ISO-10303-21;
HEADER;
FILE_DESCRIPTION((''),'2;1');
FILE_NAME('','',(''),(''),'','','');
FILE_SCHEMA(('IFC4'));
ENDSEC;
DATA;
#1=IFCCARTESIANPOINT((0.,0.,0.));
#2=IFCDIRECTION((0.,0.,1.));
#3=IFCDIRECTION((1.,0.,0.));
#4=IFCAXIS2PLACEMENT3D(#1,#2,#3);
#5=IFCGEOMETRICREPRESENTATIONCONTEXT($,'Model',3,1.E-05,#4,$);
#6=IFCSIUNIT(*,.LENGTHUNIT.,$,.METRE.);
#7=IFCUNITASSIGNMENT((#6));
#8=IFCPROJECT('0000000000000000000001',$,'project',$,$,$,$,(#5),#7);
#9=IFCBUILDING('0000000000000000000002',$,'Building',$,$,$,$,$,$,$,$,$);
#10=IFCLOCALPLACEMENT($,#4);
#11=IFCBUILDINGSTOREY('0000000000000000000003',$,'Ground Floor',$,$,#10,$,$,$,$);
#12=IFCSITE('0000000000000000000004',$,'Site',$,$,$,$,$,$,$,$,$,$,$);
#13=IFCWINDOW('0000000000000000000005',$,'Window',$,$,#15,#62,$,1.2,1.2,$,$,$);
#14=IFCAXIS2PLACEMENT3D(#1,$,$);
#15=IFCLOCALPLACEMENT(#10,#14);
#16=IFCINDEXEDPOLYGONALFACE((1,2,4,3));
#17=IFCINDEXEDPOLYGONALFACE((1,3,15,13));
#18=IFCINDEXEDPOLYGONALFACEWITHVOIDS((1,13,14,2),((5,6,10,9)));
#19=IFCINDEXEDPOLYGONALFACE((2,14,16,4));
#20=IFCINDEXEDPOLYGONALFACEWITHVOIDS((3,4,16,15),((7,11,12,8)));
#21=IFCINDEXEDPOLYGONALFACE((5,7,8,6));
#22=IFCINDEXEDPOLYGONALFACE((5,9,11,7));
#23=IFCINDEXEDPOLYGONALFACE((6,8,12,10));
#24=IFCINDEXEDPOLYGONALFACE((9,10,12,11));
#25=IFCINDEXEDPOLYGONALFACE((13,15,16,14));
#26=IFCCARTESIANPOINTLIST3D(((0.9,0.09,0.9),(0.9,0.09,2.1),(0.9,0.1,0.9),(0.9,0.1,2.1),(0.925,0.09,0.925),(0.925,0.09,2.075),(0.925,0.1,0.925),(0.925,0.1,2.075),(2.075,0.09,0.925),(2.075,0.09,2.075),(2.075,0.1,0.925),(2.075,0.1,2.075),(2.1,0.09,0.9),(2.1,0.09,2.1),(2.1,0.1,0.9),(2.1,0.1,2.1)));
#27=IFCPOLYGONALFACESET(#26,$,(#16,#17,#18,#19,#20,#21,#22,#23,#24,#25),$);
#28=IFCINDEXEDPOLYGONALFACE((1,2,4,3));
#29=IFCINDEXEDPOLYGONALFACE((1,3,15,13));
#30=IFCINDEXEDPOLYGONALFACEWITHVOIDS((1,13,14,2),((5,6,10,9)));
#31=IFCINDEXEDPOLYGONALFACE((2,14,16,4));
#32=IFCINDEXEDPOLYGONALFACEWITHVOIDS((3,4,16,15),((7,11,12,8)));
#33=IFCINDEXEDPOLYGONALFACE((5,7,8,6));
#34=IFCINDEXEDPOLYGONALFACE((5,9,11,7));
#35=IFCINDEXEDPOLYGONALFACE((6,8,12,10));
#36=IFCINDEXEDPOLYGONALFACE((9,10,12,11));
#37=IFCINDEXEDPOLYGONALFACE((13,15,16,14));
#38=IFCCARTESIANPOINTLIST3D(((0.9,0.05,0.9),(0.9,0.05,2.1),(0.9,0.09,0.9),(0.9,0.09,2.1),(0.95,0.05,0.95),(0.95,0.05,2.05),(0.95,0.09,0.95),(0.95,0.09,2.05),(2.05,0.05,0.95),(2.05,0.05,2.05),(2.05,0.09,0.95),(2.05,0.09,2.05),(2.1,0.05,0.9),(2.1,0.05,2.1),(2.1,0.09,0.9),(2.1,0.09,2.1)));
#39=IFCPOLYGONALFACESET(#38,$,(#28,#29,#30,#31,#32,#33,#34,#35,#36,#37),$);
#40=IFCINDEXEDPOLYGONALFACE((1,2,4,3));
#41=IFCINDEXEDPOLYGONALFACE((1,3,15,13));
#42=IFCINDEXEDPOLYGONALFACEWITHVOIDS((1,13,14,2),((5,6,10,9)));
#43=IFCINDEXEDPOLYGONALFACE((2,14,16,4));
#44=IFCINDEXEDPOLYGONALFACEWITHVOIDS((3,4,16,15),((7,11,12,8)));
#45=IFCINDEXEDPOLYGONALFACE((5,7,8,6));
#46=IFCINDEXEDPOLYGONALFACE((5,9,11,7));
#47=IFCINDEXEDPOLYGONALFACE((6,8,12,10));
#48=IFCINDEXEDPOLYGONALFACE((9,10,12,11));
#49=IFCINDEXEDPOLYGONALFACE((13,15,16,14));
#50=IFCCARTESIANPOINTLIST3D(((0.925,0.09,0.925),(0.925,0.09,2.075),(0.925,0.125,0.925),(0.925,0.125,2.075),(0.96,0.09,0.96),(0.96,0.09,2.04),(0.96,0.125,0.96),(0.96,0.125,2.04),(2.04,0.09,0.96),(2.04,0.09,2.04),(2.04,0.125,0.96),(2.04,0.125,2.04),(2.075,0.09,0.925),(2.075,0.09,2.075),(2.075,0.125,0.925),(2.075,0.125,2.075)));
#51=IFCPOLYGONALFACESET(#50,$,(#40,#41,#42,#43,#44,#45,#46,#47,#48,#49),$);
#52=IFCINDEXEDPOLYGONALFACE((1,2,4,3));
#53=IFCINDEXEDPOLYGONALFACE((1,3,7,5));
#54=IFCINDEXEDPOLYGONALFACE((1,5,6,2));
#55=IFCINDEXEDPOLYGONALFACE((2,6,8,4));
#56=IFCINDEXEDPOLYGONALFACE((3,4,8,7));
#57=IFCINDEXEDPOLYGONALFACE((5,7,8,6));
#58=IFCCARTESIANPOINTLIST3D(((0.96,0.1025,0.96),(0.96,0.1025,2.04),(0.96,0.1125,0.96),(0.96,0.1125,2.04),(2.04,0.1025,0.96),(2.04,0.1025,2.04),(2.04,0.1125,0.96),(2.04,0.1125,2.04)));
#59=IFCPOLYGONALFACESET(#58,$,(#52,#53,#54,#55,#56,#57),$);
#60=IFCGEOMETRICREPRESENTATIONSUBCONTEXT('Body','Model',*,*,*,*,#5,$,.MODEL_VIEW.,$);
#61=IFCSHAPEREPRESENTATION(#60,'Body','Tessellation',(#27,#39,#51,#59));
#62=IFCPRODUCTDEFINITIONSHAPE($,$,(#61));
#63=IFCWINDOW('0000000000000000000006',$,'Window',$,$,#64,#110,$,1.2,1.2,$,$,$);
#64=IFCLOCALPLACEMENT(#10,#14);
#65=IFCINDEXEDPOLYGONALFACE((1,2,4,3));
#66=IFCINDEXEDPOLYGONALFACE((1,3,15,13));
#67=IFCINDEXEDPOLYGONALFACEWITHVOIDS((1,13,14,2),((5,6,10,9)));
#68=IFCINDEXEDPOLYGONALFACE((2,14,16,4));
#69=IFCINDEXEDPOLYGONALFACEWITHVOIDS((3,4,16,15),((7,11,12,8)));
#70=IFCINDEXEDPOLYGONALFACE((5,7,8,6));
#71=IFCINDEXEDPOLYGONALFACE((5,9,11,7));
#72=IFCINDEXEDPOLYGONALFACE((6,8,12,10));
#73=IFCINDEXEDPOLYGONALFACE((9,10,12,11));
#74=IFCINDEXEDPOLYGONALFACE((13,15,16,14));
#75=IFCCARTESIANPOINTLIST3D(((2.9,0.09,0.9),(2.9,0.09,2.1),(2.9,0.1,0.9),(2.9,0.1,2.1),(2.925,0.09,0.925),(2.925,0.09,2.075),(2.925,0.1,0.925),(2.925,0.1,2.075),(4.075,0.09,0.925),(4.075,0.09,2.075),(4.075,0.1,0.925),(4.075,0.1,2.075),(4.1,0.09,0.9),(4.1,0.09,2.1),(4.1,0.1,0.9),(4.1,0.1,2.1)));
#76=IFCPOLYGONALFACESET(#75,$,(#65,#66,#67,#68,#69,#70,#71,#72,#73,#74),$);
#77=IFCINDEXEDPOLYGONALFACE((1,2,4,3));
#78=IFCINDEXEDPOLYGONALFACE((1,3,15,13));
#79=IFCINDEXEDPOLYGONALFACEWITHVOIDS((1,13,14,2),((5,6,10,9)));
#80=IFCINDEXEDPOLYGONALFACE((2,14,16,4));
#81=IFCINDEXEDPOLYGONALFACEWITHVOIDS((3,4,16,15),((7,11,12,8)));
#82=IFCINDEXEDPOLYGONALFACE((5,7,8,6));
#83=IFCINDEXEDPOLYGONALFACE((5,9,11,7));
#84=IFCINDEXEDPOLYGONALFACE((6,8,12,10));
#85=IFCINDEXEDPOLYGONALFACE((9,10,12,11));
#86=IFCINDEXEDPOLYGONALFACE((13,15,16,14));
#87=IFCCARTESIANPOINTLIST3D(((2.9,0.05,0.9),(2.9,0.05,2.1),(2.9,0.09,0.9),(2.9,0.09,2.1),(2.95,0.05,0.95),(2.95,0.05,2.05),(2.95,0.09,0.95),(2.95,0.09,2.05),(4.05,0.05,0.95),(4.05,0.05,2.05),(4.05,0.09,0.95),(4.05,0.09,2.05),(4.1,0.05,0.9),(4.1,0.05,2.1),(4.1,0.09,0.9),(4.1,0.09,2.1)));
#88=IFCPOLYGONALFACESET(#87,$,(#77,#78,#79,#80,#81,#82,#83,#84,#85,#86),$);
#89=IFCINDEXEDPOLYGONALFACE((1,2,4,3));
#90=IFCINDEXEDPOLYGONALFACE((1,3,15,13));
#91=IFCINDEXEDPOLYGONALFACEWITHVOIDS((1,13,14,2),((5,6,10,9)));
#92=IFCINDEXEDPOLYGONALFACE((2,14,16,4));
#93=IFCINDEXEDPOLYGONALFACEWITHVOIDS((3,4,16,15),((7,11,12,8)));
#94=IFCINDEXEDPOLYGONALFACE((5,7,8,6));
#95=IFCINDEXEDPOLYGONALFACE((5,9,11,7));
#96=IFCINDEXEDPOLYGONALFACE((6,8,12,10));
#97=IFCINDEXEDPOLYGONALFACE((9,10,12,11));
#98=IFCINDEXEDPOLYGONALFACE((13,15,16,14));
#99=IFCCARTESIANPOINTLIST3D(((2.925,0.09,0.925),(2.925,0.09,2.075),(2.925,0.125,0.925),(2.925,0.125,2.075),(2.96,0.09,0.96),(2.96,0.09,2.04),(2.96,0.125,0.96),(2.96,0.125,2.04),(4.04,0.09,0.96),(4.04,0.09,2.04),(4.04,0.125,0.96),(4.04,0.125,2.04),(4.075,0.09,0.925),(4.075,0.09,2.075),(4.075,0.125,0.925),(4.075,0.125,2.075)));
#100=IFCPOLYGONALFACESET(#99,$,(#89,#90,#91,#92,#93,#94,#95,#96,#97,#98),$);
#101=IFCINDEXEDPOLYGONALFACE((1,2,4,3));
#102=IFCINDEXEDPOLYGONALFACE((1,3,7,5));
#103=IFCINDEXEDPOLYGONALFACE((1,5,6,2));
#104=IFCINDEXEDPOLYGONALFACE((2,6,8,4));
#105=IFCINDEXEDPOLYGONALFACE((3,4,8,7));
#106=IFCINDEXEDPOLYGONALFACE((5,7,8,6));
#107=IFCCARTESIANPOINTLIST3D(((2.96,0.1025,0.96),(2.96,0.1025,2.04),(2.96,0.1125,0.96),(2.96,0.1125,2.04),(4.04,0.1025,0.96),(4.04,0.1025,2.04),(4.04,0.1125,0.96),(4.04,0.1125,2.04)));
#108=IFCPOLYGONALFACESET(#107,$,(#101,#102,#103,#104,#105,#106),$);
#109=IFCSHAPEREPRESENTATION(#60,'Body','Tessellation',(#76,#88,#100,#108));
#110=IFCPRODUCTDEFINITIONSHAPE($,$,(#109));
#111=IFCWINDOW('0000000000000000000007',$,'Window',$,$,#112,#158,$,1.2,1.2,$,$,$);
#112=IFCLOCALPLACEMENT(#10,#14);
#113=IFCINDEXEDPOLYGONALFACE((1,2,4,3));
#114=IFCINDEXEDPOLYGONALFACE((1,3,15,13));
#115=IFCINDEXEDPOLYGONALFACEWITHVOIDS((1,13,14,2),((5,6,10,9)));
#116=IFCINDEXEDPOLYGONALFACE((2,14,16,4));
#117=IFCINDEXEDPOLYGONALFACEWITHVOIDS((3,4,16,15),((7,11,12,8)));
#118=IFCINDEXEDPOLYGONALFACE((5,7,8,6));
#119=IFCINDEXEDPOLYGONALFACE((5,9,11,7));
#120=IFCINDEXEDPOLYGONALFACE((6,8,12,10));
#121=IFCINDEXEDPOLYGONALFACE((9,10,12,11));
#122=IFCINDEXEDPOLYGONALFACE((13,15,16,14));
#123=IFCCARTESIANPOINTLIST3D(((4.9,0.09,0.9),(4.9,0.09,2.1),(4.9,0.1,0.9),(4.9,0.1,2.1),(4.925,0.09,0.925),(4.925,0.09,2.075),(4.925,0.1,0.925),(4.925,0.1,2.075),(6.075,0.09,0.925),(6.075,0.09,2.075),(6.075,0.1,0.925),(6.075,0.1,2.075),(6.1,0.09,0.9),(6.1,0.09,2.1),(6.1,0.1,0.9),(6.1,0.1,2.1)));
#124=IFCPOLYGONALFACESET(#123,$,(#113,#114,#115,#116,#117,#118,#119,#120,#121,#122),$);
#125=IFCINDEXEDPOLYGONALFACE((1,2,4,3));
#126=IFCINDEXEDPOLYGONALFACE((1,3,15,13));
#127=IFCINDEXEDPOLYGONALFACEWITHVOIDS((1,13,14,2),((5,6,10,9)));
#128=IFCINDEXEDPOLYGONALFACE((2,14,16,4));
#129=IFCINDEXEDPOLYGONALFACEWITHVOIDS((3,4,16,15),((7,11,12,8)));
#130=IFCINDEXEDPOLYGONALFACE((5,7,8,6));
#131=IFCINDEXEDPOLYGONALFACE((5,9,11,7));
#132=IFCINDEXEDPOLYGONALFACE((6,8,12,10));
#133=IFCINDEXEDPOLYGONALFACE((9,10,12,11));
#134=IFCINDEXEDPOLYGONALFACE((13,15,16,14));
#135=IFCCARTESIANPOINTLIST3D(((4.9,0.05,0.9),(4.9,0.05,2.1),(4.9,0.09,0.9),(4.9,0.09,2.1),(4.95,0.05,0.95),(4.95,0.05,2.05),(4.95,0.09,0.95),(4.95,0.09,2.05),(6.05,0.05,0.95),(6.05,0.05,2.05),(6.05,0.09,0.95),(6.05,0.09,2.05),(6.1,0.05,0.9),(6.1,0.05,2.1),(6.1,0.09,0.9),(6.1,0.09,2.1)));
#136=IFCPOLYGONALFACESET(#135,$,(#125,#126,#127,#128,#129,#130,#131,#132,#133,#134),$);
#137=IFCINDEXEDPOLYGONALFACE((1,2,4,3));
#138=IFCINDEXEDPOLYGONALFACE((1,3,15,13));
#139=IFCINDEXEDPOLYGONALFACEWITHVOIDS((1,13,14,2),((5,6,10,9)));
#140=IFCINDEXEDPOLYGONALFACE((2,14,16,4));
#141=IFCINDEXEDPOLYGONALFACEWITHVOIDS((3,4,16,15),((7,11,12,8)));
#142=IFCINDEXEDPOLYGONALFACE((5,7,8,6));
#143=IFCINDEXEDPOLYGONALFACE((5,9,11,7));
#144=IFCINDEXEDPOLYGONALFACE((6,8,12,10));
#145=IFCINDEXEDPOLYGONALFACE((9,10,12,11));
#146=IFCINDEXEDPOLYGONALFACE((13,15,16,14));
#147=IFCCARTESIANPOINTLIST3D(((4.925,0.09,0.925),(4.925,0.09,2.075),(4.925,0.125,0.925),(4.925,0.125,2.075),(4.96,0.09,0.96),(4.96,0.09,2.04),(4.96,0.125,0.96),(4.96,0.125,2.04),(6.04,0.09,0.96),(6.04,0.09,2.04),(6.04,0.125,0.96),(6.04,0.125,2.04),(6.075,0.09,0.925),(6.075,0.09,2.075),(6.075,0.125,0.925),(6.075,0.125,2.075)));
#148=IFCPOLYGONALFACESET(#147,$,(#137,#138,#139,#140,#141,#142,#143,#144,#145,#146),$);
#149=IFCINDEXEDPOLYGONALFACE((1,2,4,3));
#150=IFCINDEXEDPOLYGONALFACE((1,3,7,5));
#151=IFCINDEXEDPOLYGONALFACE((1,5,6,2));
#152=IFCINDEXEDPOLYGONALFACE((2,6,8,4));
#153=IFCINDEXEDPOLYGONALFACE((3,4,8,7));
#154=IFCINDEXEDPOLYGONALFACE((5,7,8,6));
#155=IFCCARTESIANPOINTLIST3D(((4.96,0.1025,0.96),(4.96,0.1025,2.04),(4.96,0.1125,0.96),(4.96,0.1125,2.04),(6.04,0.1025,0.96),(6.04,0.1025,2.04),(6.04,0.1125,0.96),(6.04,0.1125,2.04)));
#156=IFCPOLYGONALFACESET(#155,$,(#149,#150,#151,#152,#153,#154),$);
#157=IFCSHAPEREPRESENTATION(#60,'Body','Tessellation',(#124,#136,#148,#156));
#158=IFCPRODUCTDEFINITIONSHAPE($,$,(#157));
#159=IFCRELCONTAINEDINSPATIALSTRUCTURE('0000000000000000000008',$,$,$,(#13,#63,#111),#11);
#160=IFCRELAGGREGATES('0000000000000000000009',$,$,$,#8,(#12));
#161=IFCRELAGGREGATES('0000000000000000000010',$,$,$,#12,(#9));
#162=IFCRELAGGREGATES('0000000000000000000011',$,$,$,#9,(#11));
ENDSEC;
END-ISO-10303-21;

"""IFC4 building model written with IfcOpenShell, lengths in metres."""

from ifc_helpers import new_model, si_unit, frame, origin_with_axes, place, context, subcontext, project, spatial, line, indexed_curve, outline, extrude, element, save


model = new_model("IFC4")

# Units and contexts
model_context = context("Model", 3, precision=1e-05, world=origin_with_axes())
body_context = subcontext(model_context, "Body", "Model", "MODEL_VIEW")
ifc_project = project(units=[si_unit("LENGTHUNIT", "METRE")], contexts=[model_context])

# Site, building, storey
site = spatial("IfcSite", under=ifc_project, Name="Site")
building = spatial("IfcBuilding", under=site, Name="Building")
storey_placement = place(None, origin_with_axes())
storey = spatial("IfcBuildingStorey", under=building, at=storey_placement, Name="Ground Floor")

# Windows
for number, where, z_axis, x_axis, name in (
    (1, (0.9, 0.0, 0.9), (0.0, 0.0, 1.0), (1.0, 0.0, 0.0), "Window"),
    (2, (2.9, 0.0, 0.9), (0.0, 0.0, 1.0), (1.0, 0.0, 0.0), "Window"),
    (3, (4.9, 0.0, 0.9), (0.0, 0.0, 1.0), (1.0, 0.0, 0.0), "Window"),
):
    element("IfcWindow", number, at=place(storey_placement, frame(where, z_axis=z_axis, x_axis=x_axis)), inside=storey, Name=name, OverallHeight=1.2, OverallWidth=1.2, context=body_context, shape_type="SweptSolid", body=[
        extrude(outline(indexed_curve([(0.0, 0.0), (1.2, 0.0), (1.2, 1.2), (0.0, 1.2)], segments=[line(1, 2, 3, 4, 1)]), holes=[indexed_curve([(0.025, 0.025), (1.175, 0.025), (1.175, 1.175), (0.025, 1.175)], segments=[line(1, 2, 3, 4, 1)])]), frame((0.0, 0.09, 0.0), z_axis=(0.0, -1.0, 0.0), x_axis=(1.0, 0.0, 0.0)), (0.0, 0.0, -1.0), 0.01),
        extrude(outline(indexed_curve([(0.0, 0.0), (1.2, 0.0), (1.2, 1.2), (0.0, 1.2)], segments=[line(1, 2, 3, 4, 1)]), holes=[indexed_curve([(0.05, 0.05), (1.15, 0.05), (1.15, 1.15), (0.05, 1.15)], segments=[line(1, 2, 3, 4, 1)])]), frame((0.0, 0.05, 0.0), z_axis=(0.0, -1.0, 0.0), x_axis=(1.0, 0.0, 0.0)), (0.0, 0.0, -1.0), 0.04),
        extrude(outline(indexed_curve([(0.0, 0.0), (1.15, 0.0), (1.15, 1.15), (0.0, 1.15)], segments=[line(1, 2, 3, 4, 1)]), holes=[indexed_curve([(0.035, 0.035), (1.115, 0.035), (1.115, 1.115), (0.035, 1.115)], segments=[line(1, 2, 3, 4, 1)])]), frame((0.025, 0.09, 0.025), z_axis=(0.0, -1.0, 0.0), x_axis=(1.0, 0.0, 0.0)), (0.0, 0.0, -1.0), 0.035),
        extrude(outline(indexed_curve([(0.035, 0.035), (1.115, 0.035), (1.115, 1.115), (0.035, 1.115)], segments=[line(1, 2, 3, 4, 1)])), frame((0.025, 0.1025, 0.025), z_axis=(0.0, -1.0, 0.0), x_axis=(1.0, 0.0, 0.0)), (0.0, 0.0, -1.0), 0.01),
    ])

save(model, "model.ifc")
